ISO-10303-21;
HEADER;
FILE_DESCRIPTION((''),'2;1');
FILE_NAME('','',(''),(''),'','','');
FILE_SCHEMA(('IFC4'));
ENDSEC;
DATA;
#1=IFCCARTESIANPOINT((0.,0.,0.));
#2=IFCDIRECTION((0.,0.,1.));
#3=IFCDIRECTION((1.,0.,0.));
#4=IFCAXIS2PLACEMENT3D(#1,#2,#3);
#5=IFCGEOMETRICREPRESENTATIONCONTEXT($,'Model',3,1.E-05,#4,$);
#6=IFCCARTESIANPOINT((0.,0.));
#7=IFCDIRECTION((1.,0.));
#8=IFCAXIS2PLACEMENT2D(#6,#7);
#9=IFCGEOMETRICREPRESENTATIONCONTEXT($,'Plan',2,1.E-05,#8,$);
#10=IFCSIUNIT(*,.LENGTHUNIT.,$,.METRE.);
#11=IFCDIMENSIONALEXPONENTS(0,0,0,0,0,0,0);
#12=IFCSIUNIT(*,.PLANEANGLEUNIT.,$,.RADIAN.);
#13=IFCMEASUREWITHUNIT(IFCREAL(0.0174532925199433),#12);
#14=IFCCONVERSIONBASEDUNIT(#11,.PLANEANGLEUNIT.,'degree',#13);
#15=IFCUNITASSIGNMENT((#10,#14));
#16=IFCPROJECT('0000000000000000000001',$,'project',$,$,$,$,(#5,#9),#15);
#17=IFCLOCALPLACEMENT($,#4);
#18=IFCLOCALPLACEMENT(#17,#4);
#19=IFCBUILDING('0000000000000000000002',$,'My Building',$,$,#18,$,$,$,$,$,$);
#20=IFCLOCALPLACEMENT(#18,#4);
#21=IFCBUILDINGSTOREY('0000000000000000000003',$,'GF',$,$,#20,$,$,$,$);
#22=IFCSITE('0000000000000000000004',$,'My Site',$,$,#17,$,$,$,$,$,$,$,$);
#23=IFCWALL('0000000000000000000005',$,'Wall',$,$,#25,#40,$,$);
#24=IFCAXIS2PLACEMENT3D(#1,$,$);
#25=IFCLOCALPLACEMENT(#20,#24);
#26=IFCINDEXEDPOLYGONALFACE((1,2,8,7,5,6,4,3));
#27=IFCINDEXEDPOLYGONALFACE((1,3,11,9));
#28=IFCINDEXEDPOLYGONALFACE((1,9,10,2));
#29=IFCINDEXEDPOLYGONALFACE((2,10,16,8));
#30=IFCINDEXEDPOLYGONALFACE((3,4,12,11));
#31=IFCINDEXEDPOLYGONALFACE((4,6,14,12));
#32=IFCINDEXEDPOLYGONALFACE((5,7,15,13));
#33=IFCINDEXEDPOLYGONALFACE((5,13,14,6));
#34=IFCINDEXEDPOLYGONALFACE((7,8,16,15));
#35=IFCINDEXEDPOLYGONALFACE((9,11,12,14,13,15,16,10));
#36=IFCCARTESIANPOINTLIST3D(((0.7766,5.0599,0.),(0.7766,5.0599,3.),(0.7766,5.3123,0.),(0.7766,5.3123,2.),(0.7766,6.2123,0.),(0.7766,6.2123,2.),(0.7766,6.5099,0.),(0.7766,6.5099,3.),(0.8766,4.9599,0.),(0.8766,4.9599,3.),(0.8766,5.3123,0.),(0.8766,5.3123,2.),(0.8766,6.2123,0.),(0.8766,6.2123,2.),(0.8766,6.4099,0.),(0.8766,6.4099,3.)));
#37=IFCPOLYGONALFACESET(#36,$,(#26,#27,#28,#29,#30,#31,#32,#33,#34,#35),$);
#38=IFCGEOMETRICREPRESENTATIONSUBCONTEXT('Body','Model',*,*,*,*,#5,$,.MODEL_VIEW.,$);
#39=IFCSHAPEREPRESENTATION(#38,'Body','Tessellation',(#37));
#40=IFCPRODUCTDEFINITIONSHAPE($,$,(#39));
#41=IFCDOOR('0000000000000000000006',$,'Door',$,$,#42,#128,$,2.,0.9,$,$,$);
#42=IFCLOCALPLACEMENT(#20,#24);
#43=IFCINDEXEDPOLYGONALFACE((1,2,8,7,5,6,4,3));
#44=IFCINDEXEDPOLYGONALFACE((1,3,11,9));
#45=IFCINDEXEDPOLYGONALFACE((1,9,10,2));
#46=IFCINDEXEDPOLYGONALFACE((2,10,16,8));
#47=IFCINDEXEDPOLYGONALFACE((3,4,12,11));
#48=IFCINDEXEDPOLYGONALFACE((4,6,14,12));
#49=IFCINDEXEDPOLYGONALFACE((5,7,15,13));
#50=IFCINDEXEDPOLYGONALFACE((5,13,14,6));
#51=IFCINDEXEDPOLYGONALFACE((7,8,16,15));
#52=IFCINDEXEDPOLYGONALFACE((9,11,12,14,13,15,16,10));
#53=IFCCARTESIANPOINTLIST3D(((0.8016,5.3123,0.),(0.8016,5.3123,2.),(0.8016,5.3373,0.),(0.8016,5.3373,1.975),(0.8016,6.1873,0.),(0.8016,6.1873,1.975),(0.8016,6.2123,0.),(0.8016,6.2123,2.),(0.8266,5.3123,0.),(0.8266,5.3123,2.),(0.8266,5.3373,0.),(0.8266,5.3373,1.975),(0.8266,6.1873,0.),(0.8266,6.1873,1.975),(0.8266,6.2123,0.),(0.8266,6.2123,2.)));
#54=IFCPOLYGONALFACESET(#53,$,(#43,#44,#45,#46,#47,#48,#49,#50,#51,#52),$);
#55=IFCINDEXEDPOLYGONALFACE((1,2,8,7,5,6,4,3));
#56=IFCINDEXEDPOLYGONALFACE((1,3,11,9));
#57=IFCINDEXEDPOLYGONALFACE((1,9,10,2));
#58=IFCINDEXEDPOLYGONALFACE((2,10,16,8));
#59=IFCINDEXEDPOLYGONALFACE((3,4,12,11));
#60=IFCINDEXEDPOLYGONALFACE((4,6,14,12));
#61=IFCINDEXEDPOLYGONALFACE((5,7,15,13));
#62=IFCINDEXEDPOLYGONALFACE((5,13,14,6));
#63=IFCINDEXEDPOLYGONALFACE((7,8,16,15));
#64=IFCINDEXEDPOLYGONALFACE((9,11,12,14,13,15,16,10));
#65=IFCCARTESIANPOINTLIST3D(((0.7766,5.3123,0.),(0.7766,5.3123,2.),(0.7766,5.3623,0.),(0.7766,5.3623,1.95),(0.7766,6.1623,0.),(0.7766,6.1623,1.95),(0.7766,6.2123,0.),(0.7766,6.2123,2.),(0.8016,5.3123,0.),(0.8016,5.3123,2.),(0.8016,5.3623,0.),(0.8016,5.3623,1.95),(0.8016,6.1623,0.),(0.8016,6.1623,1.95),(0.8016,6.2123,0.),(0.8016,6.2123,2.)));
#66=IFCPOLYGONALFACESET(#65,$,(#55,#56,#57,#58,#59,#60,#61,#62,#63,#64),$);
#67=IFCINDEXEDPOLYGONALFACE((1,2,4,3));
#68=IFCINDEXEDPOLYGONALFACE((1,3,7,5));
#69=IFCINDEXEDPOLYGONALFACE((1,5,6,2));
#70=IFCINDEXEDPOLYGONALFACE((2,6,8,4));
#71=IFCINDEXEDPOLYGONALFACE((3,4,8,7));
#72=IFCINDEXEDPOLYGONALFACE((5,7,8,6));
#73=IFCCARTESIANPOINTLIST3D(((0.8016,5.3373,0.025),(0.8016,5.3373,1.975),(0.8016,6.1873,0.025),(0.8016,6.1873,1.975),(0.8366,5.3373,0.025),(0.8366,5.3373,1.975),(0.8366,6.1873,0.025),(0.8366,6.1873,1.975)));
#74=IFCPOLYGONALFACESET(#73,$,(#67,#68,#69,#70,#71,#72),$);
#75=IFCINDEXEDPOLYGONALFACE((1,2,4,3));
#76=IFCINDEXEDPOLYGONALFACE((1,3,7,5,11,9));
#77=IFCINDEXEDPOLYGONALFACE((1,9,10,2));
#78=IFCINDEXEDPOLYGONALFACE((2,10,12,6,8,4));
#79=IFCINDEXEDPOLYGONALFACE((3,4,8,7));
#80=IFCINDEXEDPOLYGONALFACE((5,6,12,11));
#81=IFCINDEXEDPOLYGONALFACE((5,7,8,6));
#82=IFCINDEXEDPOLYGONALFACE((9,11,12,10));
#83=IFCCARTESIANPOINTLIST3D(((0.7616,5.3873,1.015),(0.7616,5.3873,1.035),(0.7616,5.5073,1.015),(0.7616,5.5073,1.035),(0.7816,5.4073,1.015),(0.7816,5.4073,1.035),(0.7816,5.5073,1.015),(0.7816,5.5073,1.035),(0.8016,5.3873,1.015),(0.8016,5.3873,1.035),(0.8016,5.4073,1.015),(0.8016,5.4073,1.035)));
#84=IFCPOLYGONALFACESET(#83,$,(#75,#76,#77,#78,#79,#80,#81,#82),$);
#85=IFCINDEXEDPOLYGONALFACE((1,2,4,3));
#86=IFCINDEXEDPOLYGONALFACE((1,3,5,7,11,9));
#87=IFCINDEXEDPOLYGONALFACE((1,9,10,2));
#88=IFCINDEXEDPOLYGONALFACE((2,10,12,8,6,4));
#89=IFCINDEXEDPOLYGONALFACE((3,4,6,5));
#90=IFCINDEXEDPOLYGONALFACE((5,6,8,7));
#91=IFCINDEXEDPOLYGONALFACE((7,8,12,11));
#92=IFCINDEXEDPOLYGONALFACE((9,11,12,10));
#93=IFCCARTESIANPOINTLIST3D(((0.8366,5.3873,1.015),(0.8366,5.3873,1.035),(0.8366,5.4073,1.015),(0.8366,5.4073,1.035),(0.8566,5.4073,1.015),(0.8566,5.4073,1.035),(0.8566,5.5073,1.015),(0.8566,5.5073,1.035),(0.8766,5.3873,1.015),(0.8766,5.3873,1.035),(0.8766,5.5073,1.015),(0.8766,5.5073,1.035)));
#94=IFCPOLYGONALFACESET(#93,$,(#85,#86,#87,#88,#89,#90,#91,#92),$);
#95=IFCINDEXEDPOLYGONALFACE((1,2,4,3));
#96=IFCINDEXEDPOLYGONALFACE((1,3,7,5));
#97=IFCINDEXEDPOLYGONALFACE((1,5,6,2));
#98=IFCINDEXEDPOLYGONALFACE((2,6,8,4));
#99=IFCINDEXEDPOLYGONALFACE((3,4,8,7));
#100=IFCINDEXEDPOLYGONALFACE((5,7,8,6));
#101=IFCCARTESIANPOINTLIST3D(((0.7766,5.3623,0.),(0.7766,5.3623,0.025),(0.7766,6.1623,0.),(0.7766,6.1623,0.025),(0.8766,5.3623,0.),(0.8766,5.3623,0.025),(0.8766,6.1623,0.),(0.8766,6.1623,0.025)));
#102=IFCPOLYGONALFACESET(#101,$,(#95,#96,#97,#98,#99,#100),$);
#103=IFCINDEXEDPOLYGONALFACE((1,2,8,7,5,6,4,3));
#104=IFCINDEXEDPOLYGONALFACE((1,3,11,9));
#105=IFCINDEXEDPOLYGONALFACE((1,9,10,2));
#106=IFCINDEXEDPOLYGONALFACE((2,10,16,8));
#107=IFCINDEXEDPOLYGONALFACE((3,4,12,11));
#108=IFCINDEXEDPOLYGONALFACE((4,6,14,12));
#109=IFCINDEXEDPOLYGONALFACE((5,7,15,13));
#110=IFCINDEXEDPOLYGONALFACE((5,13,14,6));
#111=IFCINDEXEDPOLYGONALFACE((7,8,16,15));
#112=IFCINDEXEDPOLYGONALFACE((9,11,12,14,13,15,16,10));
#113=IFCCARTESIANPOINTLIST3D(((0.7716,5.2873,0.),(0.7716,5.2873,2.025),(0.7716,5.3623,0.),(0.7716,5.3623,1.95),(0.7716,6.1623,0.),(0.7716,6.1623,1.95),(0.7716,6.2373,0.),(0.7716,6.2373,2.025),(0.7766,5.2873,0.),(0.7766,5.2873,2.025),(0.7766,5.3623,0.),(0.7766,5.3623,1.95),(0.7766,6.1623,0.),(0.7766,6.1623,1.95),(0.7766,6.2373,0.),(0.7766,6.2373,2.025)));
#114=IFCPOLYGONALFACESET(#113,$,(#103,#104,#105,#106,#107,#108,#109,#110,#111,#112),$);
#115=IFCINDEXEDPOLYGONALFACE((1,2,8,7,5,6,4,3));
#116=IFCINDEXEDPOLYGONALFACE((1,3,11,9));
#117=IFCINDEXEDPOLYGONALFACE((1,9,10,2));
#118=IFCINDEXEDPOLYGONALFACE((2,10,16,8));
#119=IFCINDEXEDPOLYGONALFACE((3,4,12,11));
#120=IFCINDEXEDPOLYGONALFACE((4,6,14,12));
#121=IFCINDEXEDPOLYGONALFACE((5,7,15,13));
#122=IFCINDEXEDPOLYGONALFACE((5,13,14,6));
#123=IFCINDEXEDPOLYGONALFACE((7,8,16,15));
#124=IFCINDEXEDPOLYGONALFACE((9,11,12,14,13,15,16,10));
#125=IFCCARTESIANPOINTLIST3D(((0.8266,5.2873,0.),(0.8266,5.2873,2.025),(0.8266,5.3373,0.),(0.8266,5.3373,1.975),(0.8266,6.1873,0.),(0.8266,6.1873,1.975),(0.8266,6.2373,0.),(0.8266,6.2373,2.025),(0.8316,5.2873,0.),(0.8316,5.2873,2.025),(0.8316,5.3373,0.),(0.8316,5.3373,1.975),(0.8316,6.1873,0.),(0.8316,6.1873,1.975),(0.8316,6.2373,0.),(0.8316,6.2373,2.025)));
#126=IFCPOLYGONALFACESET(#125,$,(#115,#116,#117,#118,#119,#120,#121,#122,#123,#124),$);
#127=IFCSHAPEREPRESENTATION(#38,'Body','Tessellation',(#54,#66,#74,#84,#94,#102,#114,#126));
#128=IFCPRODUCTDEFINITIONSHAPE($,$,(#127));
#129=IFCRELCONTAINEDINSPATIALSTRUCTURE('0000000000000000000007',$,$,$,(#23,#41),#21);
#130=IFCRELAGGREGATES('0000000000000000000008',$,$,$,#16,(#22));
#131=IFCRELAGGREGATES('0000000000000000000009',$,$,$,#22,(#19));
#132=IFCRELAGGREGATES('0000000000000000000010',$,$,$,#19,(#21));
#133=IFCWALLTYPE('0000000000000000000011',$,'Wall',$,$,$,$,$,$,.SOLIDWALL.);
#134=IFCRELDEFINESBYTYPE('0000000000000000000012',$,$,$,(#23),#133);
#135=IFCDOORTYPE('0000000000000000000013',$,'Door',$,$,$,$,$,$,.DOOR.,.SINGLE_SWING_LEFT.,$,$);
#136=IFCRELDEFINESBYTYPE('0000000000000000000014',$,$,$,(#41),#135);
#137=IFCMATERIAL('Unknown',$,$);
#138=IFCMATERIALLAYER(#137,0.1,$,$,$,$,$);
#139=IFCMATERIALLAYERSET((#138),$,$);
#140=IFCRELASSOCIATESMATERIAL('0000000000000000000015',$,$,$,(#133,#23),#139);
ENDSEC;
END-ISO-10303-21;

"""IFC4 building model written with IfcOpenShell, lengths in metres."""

from ifc_helpers import new_model, entity, si_unit, converted_unit, frame, origin_with_axes, origin_2d_with_axis, place, context, subcontext, project, spatial, line, indexed_curve, outline, extrude, shape, source, transform, mapped, material, layer, layer_set, layer_usage, type_object, type_shapes, element, fill, save


model = new_model("IFC4")

# Units and contexts
model_context = context("Model", 3, precision=1e-05, world=origin_with_axes())
plan_context = context("Plan", 2, precision=1e-05, world=origin_2d_with_axis())
body_context_1 = subcontext(model_context, "Body", "Model", "MODEL_VIEW")
body_context_2 = subcontext(plan_context, "Body", "Plan", "PLAN_VIEW")
ifc_project = project(units=[si_unit("LENGTHUNIT", "METRE"), converted_unit("PLANEANGLEUNIT", "degree", entity("IfcReal", 0.0174532925199433), si_unit("PLANEANGLEUNIT", "RADIAN"), dimensions=[0, 0, 0, 0, 0, 0, 0])], contexts=[model_context, plan_context])

# Site, building, storey
site_placement = place(None, origin_with_axes())
site = spatial("IfcSite", under=ifc_project, at=site_placement, Name="My Site")
building_placement = place(site_placement, origin_with_axes())
building = spatial("IfcBuilding", under=site, at=building_placement, Name="My Building")
storey_placement = place(building_placement, origin_with_axes())
storey = spatial("IfcBuildingStorey", under=building, at=storey_placement, Name="GF")

# Shared definitions
ifc_material = material(Name="Unknown")

# Shared definitions
ifc_layer_1 = layer(ifc_material, 0.1)
ifc_layer_set_1 = layer_set([ifc_layer_1])
wall_type = type_object("IfcWallType", Name="Wall", PredefinedType="SOLIDWALL", material=ifc_layer_set_1)
shared_shape_1 = source(origin_with_axes(), body_context_1, "Body", "SweptSolid", [
    extrude(outline(indexed_curve([(0.0, 0.0), (0.9, 0.0), (0.9, 2.0), (0.0, 2.0)], segments=[line(1, 2, 3, 4, 1)])), frame((0.0, -0.6, 0.0), z_axis=(0.0, -1.0, 0.0), x_axis=(1.0, 0.0, 0.0)), (0.0, 0.0, -1.0), 1.2),
])
door_type = type_object("IfcDoorType", Name="Door", OperationType="SINGLE_SWING_LEFT", PredefinedType="DOOR")
shared_shape_2 = source(origin_with_axes(), body_context_1, "Body", "SweptSolid", [
    extrude(outline(indexed_curve([(0.0, 0.0), (0.0, 2.0), (0.9, 2.0), (0.9, 0.0), (0.875, 0.0), (0.875, 1.975), (0.025, 1.975), (0.025, 0.0)], segments=[line(1, 2, 3, 4, 5, 6, 7, 8, 1)])), frame((0.0, 0.025, 0.0), z_axis=(0.0, -1.0, 0.0), x_axis=(1.0, 0.0, 0.0)), (0.0, 0.0, -1.0), 0.025),
    extrude(outline(indexed_curve([(0.0, 0.0), (0.0, 2.0), (0.9, 2.0), (0.9, 0.0), (0.85, 0.0), (0.85, 1.95), (0.05, 1.95), (0.05, 0.0)], segments=[line(1, 2, 3, 4, 5, 6, 7, 8, 1)])), frame((0.0, 0.0, 0.0), z_axis=(0.0, -1.0, 0.0), x_axis=(1.0, 0.0, 0.0)), (0.0, 0.0, -1.0), 0.025),
    extrude(outline(indexed_curve([(0.0, 0.0), (0.85, 0.0), (0.85, 0.035), (0.0, 0.035)], segments=[line(1, 2, 3, 4, 1)])), frame((0.025, 0.025, 0.025), z_axis=(0.0, 0.0, 1.0), x_axis=(1.0, 0.0, 0.0)), (0.0, 0.0, 1.0), 1.95),
    extrude(outline(indexed_curve([(0.0, 0.0), (0.0, -0.04), (-0.12, -0.04), (-0.12, -0.02), (-0.02, -0.02), (-0.02, 0.0)], segments=[line(1, 2, 3, 4, 5, 6, 1)])), frame((0.825, 0.025, 1.015), z_axis=(0.0, 0.0, 1.0), x_axis=(1.0, 0.0, 0.0)), (0.0, 0.0, 1.0), 0.02),
    extrude(outline(indexed_curve([(0.0, 0.0), (0.0, 0.04), (-0.12, 0.04), (-0.12, 0.02), (-0.02, 0.02), (-0.02, 0.0)], segments=[line(1, 2, 3, 4, 5, 6, 1)])), frame((0.825, 0.06, 1.015), z_axis=(0.0, 0.0, 1.0), x_axis=(1.0, 0.0, 0.0)), (0.0, 0.0, 1.0), 0.02),
    extrude(outline(indexed_curve([(0.0, 0.0), (0.8, 0.0), (0.8, 0.1), (0.0, 0.1)], segments=[line(1, 2, 3, 4, 1)])), frame((0.05, 0.0, 0.0), z_axis=(0.0, 0.0, 1.0), x_axis=(1.0, 0.0, 0.0)), (0.0, 0.0, 1.0), 0.025),
    extrude(outline(indexed_curve([(0.0, 0.0), (0.0, 2.025), (0.95, 2.025), (0.95, 0.0), (0.875, 0.0), (0.875, 1.95), (0.075, 1.95), (0.075, 0.0)], segments=[line(1, 2, 3, 4, 5, 6, 7, 8, 1)])), frame((-0.025, -0.005, 0.0), z_axis=(0.0, -1.0, 0.0), x_axis=(1.0, 0.0, 0.0)), (0.0, 0.0, -1.0), 0.005),
    extrude(outline(indexed_curve([(0.0, 0.0), (0.0, 2.025), (0.95, 2.025), (0.95, 0.0), (0.9, 0.0), (0.9, 1.975), (0.05, 1.975), (0.05, 0.0)], segments=[line(1, 2, 3, 4, 5, 6, 7, 8, 1)])), frame((-0.025, 0.05, 0.0), z_axis=(0.0, -1.0, 0.0), x_axis=(1.0, 0.0, 0.0)), (0.0, 0.0, -1.0), 0.005),
])
shared_shape_3 = source(origin_with_axes(), body_context_2, "Body", "Curve2D", [
    entity("IfcIndexedPolyCurve", entity("IfcCartesianPointList2D", [[0.0, 0.0], [0.0, 0.05], [0.025, 0.05], [0.025, 0.025], [0.05, 0.025], [0.05, 0.0]]), [entity("IfcLineIndex", [1, 2, 3, 4, 5, 6, 1])]),
    entity("IfcIndexedPolyCurve", entity("IfcCartesianPointList2D", [[0.9, 0.0], [0.9, 0.05], [0.875, 0.05], [0.875, 0.025], [0.85, 0.025], [0.85, 0.0]]), [entity("IfcLineIndex", [1, 2, 3, 4, 5, 6, 1])]),
    entity("IfcTrimmedCurve", entity("IfcEllipse", entity("IfcAxis2Placement2D", entity("IfcCartesianPoint", [0.06, 0.05]), entity("IfcDirection", [1.0, 0.0])), 0.815, 0.85), [entity("IfcCartesianPoint", [0.875, 0.05])], [entity("IfcCartesianPoint", [0.06, 0.9])], True, "CARTESIAN"),
    entity("IfcIndexedPolyCurve", entity("IfcCartesianPointList2D", [[0.025, 0.05], [0.06, 0.05], [0.06, 0.9], [0.025, 0.9]]), [entity("IfcLineIndex", [1, 2, 3, 4, 1])]),
])
type_shapes(door_type, [shared_shape_2, shared_shape_3])

# Wall, opening, door
ifc_layer_usage_1 = layer_usage(ifc_layer_set_1, "AXIS2", "POSITIVE", 0.0)
wall_1_placement = place(storey_placement, frame((0.7766, 6.5099, 0.0), z_axis=(0.0, 0.0, 1.0), x_axis=(0.0, -1.0, 0.0)))
wall_1 = element("IfcWall", 1, at=wall_1_placement, inside=storey, type_object=wall_type, material=ifc_layer_usage_1, Name="Wall", context=body_context_1, shape_type="SweptSolid", body=[
    extrude(outline(indexed_curve([(0.0, 0.0), (0.1, 0.1), (1.55, 0.1), (1.45, 0.0)], segments=[line(1, 2, 3, 4, 1)])), origin_with_axes(), (0.0, 0.0, 1.0), 3.0),
])
opening_1_placement = place(wall_1_placement, frame((0.2976, 0.0, 0.0), z_axis=(0.0, 0.0, 1.0), x_axis=(1.0, 0.0, 0.0)))
opening_1 = element("IfcOpeningElement", 2, at=opening_1_placement, cuts=wall_1, PredefinedType="OPENING", context=body_context_1, shape_type="MappedRepresentation", body=[
    mapped(shared_shape_1, transform((0.0, 0.0, 0.0), x_axis=(1.0, 0.0, 0.0), y_axis=(0.0, 1.0, 0.0), z_axis=(0.0, 0.0, 1.0), scale=1.0)),
])
door_1_placement = place(opening_1_placement, frame((0.0, 0.0, 0.0), z_axis=(0.0, 0.0, 1.0), x_axis=(1.0, 0.0, 0.0)))
door_1 = element("IfcDoor", 3, at=door_1_placement, inside=storey, type_object=door_type, Name="Door", OverallHeight=2.0, OverallWidth=0.9, shapes=[
    shape(body_context_1, "Body", "MappedRepresentation", [mapped(shared_shape_2, transform((0.0, 0.0, 0.0), x_axis=(1.0, 0.0, 0.0), y_axis=(0.0, 1.0, 0.0), z_axis=(0.0, 0.0, 1.0), scale=1.0))]),
    shape(body_context_2, "Body", "MappedRepresentation", [mapped(shared_shape_3, transform((0.0, 0.0, 0.0), x_axis=(1.0, 0.0, 0.0), y_axis=(0.0, 1.0, 0.0), z_axis=(0.0, 0.0, 1.0), scale=1.0))]),
])
fill(opening_1, door_1)

save(model, "model.ifc")
